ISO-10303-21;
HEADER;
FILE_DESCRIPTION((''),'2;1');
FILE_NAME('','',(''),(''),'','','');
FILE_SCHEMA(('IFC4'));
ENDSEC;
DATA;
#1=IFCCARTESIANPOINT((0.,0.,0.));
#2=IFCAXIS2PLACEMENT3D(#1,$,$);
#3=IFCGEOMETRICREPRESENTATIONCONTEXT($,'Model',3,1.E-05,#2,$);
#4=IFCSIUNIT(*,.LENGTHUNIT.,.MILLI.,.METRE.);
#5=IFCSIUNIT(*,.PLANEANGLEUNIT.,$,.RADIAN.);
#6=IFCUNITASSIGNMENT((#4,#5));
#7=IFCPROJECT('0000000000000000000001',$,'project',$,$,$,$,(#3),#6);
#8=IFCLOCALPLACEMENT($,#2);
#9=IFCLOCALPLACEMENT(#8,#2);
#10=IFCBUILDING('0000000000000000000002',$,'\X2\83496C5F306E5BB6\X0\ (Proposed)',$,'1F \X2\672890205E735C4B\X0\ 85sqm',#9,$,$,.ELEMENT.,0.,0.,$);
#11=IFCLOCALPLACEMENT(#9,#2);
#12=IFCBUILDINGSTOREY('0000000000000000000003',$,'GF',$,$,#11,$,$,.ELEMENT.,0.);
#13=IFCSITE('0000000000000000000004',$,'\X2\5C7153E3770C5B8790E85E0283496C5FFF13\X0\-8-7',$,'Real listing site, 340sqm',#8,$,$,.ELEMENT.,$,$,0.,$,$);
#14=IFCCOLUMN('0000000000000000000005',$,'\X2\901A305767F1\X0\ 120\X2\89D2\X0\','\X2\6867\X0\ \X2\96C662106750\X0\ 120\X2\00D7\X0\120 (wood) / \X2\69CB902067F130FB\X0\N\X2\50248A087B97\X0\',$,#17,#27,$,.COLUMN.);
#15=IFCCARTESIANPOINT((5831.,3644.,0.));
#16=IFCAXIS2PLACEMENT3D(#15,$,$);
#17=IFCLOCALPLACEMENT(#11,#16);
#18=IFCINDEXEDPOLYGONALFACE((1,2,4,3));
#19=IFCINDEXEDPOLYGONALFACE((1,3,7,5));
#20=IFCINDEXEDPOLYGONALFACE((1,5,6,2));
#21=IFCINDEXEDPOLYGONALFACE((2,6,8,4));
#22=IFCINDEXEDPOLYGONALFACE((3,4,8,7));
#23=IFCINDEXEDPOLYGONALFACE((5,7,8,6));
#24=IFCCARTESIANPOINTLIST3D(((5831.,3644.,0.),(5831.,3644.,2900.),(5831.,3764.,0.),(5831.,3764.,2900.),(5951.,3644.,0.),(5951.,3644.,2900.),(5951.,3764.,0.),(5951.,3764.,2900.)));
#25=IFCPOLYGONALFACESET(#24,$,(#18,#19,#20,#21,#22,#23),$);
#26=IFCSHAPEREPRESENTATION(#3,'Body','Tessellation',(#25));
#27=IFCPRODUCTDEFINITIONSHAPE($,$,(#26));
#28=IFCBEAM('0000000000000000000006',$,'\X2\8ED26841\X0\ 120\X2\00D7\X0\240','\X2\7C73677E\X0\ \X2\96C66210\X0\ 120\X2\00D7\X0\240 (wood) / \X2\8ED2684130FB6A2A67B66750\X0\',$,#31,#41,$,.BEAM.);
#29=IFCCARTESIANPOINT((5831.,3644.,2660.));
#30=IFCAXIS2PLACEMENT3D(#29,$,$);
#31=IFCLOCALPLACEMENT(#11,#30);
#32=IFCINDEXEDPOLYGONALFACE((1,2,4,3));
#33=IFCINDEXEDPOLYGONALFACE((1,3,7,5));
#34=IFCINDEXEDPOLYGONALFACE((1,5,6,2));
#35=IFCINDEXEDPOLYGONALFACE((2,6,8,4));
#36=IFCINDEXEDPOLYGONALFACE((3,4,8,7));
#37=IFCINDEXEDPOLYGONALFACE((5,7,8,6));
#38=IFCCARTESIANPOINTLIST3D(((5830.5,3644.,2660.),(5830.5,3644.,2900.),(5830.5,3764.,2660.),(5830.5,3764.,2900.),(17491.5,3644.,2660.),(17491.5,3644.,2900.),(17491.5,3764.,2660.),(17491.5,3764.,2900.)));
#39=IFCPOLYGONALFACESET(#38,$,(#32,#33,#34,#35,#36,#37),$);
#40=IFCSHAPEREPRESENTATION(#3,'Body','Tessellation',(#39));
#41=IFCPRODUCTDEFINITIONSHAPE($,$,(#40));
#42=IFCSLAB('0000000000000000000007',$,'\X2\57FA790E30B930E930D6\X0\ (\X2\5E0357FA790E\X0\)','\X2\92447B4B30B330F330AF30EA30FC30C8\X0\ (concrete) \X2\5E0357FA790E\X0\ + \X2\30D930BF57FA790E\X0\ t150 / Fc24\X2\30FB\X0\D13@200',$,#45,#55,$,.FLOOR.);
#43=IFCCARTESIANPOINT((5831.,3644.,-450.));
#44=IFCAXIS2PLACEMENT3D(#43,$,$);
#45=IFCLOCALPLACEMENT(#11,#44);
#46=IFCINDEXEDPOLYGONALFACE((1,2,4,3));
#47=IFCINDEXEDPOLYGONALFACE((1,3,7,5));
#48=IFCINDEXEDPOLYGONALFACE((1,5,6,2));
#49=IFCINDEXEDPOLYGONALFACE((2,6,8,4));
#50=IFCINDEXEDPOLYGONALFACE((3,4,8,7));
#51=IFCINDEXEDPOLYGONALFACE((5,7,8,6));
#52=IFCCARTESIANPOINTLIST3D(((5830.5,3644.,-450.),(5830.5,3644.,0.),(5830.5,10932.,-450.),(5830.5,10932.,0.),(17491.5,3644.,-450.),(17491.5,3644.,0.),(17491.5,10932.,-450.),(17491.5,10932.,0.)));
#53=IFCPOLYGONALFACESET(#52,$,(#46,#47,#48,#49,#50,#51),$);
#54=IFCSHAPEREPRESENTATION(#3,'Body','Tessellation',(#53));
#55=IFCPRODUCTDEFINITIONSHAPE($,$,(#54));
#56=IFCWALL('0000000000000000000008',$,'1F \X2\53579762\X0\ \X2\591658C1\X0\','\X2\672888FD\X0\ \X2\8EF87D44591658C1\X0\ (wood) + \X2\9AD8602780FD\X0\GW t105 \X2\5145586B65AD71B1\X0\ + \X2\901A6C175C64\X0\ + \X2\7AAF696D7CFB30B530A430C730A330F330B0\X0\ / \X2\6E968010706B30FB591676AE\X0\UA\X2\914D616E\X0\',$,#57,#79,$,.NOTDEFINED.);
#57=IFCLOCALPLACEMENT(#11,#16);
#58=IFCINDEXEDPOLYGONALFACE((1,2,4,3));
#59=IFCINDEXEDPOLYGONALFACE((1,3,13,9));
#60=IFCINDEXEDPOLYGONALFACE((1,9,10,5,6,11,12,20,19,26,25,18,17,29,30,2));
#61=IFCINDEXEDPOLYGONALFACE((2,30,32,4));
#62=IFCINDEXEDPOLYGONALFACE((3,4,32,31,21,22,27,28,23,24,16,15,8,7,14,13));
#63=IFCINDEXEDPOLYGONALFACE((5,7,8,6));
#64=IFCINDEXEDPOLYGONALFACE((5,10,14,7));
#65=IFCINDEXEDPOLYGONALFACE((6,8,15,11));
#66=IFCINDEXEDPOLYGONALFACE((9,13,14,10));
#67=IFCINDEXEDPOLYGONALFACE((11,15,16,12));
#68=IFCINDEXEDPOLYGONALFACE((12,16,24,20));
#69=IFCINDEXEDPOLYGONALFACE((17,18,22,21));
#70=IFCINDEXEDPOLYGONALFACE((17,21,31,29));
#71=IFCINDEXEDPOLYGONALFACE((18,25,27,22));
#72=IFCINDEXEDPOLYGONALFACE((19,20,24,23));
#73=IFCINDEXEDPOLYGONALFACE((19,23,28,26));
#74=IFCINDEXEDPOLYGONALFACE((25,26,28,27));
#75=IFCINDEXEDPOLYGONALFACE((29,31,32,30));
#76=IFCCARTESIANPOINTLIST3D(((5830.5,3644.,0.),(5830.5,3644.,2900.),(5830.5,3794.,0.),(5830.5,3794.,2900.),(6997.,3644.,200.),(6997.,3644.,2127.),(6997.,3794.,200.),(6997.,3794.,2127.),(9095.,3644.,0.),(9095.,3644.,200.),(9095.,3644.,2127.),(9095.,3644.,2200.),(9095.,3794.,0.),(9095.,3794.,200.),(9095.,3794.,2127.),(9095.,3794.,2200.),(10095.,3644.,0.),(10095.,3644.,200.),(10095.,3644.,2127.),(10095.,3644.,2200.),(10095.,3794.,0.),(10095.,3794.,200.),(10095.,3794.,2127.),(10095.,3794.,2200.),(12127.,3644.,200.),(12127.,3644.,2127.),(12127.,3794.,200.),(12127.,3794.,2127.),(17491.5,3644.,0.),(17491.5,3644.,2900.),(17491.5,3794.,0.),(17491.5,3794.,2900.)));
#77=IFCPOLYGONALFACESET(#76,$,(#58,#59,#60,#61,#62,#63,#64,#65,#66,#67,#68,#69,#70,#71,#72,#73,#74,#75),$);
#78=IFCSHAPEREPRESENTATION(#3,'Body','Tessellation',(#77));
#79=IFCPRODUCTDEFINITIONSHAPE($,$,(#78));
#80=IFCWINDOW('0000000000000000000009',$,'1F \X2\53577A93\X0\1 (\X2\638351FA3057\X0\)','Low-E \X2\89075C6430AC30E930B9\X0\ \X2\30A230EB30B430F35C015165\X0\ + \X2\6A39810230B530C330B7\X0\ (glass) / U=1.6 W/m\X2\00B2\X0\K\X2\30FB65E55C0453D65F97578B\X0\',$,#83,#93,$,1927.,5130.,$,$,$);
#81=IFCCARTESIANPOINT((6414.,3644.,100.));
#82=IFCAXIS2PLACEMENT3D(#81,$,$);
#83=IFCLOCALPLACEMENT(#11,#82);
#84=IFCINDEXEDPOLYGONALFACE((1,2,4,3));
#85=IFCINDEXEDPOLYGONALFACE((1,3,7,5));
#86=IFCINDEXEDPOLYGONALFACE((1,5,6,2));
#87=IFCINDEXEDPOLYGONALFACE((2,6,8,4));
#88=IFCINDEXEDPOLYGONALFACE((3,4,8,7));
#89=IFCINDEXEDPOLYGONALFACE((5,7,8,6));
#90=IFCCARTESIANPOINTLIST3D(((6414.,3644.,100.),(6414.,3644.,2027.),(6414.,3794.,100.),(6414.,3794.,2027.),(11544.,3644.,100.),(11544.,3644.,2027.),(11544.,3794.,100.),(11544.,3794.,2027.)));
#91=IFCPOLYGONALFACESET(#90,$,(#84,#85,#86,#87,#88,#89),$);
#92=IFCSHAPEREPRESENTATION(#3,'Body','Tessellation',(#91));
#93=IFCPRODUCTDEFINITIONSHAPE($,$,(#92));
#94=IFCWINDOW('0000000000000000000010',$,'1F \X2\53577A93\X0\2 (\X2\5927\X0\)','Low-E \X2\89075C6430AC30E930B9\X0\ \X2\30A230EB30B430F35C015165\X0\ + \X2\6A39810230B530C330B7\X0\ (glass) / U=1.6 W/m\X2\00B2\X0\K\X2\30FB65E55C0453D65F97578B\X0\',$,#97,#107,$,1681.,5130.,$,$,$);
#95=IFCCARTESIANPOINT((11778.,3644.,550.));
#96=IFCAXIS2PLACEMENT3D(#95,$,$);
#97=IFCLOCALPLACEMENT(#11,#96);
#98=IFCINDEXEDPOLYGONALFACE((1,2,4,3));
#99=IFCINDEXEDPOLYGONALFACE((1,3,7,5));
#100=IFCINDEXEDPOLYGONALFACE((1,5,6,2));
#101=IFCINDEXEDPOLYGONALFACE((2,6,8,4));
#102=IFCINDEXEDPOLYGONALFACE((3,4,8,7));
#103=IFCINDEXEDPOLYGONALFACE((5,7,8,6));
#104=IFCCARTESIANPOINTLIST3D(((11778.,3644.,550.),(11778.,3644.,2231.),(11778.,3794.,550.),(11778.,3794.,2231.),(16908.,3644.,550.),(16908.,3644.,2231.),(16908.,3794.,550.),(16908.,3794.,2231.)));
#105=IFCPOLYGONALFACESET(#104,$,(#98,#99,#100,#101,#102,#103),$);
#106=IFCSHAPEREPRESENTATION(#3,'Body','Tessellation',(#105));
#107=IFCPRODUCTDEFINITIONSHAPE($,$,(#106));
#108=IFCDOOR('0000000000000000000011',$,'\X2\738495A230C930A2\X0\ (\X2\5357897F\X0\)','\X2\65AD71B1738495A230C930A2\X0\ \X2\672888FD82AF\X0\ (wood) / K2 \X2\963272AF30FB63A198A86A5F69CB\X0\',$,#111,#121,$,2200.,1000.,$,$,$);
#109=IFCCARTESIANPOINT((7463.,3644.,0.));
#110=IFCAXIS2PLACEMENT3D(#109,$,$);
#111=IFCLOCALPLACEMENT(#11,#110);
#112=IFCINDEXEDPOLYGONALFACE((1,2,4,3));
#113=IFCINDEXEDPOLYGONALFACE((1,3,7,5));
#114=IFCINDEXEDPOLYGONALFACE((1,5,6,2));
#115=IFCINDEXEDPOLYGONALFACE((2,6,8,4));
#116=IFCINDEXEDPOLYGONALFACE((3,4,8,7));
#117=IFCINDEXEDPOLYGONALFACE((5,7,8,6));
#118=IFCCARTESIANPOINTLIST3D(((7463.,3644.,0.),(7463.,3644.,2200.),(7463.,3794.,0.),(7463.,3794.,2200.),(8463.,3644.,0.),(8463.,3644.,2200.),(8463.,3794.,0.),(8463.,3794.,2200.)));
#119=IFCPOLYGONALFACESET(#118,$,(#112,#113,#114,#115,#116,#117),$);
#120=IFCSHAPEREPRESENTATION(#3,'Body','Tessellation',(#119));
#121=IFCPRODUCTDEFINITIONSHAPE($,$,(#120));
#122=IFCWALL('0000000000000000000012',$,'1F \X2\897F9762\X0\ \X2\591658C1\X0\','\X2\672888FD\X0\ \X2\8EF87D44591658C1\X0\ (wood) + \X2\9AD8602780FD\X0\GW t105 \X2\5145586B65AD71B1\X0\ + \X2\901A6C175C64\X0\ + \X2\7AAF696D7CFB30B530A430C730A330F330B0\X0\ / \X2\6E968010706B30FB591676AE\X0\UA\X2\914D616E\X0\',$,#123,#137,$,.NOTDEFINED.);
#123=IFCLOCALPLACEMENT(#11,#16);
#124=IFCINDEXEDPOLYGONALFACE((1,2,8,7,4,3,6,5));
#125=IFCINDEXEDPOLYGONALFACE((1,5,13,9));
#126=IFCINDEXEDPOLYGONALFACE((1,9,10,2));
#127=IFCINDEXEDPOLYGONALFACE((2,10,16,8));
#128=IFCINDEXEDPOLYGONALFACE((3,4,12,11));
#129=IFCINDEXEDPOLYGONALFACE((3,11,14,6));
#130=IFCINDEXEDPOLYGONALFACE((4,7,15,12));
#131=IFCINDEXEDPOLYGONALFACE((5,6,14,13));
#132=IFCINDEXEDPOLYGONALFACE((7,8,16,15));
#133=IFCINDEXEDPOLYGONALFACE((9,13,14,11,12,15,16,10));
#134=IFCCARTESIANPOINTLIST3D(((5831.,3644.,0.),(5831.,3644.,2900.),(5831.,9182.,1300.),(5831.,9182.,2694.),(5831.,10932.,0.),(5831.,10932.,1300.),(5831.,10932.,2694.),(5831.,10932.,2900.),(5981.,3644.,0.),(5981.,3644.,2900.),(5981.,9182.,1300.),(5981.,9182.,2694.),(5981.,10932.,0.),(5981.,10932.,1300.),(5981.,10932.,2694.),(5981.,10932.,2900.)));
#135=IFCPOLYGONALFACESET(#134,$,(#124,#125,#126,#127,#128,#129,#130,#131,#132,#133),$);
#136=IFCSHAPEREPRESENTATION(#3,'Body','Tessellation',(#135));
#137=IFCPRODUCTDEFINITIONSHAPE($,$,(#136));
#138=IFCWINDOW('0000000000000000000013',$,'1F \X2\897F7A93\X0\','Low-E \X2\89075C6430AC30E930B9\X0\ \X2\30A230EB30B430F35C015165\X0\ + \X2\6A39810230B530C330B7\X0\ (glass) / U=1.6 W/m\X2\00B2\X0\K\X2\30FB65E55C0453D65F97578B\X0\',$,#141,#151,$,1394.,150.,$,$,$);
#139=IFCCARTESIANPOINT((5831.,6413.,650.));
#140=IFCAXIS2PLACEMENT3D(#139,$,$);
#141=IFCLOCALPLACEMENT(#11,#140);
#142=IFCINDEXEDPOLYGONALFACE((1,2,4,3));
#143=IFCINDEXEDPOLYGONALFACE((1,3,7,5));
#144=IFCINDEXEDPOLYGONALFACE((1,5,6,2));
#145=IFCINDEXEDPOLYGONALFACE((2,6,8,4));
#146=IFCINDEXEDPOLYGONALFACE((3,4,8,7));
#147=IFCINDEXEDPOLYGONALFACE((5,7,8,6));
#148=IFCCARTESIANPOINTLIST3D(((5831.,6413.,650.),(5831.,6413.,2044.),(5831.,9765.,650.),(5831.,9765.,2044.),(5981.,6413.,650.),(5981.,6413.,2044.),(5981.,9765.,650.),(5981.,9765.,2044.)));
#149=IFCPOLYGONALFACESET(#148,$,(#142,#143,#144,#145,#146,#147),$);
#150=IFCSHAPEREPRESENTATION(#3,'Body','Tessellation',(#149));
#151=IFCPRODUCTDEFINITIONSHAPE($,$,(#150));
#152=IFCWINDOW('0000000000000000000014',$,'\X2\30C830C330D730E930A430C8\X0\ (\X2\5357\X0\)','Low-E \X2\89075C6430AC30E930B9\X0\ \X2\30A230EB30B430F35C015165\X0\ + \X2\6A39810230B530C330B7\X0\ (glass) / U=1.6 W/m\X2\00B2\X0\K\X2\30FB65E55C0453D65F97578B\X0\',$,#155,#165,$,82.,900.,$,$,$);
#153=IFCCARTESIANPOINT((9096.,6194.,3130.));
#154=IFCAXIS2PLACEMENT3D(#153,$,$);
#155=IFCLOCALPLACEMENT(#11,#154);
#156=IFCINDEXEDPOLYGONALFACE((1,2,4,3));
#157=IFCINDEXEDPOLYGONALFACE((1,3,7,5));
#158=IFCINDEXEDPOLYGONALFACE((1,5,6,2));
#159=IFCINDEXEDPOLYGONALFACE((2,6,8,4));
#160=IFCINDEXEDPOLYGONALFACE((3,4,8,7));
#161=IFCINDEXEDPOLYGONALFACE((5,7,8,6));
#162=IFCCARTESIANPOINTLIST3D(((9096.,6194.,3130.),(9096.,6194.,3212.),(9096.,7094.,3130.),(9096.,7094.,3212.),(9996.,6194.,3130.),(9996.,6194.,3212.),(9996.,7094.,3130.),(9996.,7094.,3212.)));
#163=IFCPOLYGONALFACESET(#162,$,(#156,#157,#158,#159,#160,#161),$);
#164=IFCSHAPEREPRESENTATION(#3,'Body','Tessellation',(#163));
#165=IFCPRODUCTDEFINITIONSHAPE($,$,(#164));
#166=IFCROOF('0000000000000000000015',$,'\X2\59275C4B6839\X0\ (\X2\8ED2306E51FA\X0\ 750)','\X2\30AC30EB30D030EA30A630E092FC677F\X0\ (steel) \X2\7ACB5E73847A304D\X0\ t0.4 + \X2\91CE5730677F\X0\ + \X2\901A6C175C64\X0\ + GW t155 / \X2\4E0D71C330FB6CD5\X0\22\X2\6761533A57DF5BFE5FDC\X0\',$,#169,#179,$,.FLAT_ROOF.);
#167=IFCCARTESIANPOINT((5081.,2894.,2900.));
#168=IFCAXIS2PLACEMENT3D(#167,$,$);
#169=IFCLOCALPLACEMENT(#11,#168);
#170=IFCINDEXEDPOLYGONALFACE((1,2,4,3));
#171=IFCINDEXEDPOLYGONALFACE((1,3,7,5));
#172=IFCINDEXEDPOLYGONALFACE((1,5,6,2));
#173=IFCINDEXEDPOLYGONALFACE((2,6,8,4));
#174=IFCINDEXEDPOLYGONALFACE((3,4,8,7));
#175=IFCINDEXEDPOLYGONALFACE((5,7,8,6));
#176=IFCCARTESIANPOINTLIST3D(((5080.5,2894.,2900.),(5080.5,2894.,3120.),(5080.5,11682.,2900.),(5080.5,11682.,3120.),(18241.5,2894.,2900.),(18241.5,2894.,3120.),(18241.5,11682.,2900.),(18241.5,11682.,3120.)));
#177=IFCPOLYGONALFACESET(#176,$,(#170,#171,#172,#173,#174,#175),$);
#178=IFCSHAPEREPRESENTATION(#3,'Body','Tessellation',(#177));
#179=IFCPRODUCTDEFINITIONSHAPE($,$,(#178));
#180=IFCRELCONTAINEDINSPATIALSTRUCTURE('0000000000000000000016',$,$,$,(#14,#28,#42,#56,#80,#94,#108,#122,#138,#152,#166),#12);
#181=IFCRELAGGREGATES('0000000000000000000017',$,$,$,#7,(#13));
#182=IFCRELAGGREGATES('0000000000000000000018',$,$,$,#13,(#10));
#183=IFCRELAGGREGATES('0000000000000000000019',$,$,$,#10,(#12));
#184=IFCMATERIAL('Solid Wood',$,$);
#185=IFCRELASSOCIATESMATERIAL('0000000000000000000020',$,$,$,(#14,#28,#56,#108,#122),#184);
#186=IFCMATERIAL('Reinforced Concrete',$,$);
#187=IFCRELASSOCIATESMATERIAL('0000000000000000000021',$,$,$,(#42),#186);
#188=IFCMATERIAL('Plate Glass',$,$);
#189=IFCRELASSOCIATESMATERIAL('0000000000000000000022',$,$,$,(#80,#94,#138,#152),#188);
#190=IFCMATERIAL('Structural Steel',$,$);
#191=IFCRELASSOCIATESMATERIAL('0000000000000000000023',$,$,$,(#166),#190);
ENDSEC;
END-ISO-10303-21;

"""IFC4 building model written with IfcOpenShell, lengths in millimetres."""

from ifc_helpers import new_model, si_unit, frame, frame_2d, origin, place, context, project, spatial, rectangle, extrude, material, element, fill, save


model = new_model("IFC4")

# Units and contexts
model_context = context("Model", 3, precision=1e-05, world=origin())
ifc_project = project(units=[si_unit("LENGTHUNIT", "METRE", prefix="MILLI"), si_unit("PLANEANGLEUNIT", "RADIAN")], contexts=[model_context])

# Site, building, storey
site_placement = place(None, origin())
site = spatial("IfcSite", under=ifc_project, at=site_placement, Name="山口県宇部市草江３-8-7", ObjectType="Real listing site, 340sqm", CompositionType="ELEMENT", RefElevation=0.0)
building_placement = place(site_placement, origin())
building = spatial("IfcBuilding", under=site, at=building_placement, Name="草江の家 (Proposed)", ObjectType="1F 木造平屋 85sqm", CompositionType="ELEMENT", ElevationOfRefHeight=0.0, ElevationOfTerrain=0.0)
storey_placement = place(building_placement, origin())
storey = spatial("IfcBuildingStorey", under=building, at=storey_placement, Name="GF", CompositionType="ELEMENT", Elevation=0.0)

# Column
ifc_material_1 = material(Name="Solid Wood")
column_1_placement = place(storey_placement, frame((5831.0, 3644.0, 0.0)))
element("IfcColumn", 1, at=column_1_placement, inside=storey, material=ifc_material_1, Name="通し柱 120角", Description="桧 集成材 120×120 (wood) / 構造柱・N値計算", PredefinedType="COLUMN", context=model_context, shape_type="SweptSolid", body=[
    extrude(rectangle(XDim=120.0, YDim=120.0, at=frame_2d((60.0, 60.0))), frame((5831.0, 3644.0, 0.0)), (0.0, 0.0, 1.0), 2900.0),
])

# Beam
beam_1_placement = place(storey_placement, frame((5831.0, 3644.0, 2660.0)))
element("IfcBeam", 2, at=beam_1_placement, inside=storey, material=ifc_material_1, Name="軒桁 120×240", Description="米松 集成 120×240 (wood) / 軒桁・横架材", PredefinedType="BEAM", context=model_context, shape_type="SweptSolid", body=[
    extrude(rectangle(XDim=11661.0, YDim=120.0, at=frame_2d((5830.0, 60.0))), frame((5831.0, 3644.0, 2660.0)), (0.0, 0.0, 1.0), 240.0),
])

# Slab
ifc_material_2 = material(Name="Reinforced Concrete")
slab_1_placement = place(storey_placement, frame((5831.0, 3644.0, -450.0)))
element("IfcSlab", 3, at=slab_1_placement, inside=storey, material=ifc_material_2, Name="基礎スラブ (布基礎)", Description="鉄筋コンクリート (concrete) 布基礎 + ベタ基礎 t150 / Fc24・D13@200", PredefinedType="FLOOR", context=model_context, shape_type="SweptSolid", body=[
    extrude(rectangle(XDim=11661.0, YDim=7288.0, at=frame_2d((5830.0, 3644.0))), frame((5831.0, 3644.0, -450.0)), (0.0, 0.0, 1.0), 450.0),
])

# Wall, openings, windows, door
wall_1_placement = place(storey_placement, frame((5831.0, 3644.0, 0.0)))
wall_1 = element("IfcWall", 4, at=wall_1_placement, inside=storey, material=ifc_material_1, Name="1F 南面 外壁", Description="木製 軸組外壁 (wood) + 高性能GW t105 充填断熱 + 通気層 + 窯業系サイディング / 準耐火・外皮UA配慮", PredefinedType="NOTDEFINED", context=model_context, shape_type="SweptSolid", body=[
    extrude(rectangle(XDim=11661.0, YDim=150.0, at=frame_2d((5830.0, 75.0))), frame((5831.0, 3644.0, 0.0)), (0.0, 0.0, 1.0), 2900.0),
])
opening_1_placement = place(storey_placement, frame((6414.0, 3644.0, 100.0)))
opening_1 = element("IfcOpeningElement", 5, at=opening_1_placement, cuts=wall_1, PredefinedType="NOTDEFINED", context=model_context, shape_type="SweptSolid", body=[
    extrude(rectangle(XDim=5130.0, YDim=150.0, at=frame_2d((2565.0, 75.0))), frame((6414.0, 3644.0, 100.0)), (0.0, 0.0, 1.0), 1927.0),
])
opening_2_placement = place(storey_placement, frame((11778.0, 3644.0, 550.0)))
opening_2 = element("IfcOpeningElement", 6, at=opening_2_placement, cuts=wall_1, PredefinedType="NOTDEFINED", context=model_context, shape_type="SweptSolid", body=[
    extrude(rectangle(XDim=5130.0, YDim=150.0, at=frame_2d((2565.0, 75.0))), frame((11778.0, 3644.0, 550.0)), (0.0, 0.0, 1.0), 1681.0),
])
opening_3_placement = place(storey_placement, frame((7463.0, 3644.0, 0.0)))
opening_3 = element("IfcOpeningElement", 7, at=opening_3_placement, cuts=wall_1, PredefinedType="NOTDEFINED", context=model_context, shape_type="SweptSolid", body=[
    extrude(rectangle(XDim=1000.0, YDim=150.0, at=frame_2d((500.0, 75.0))), frame((7463.0, 3644.0, 0.0)), (0.0, 0.0, 1.0), 2200.0),
])
ifc_material_3 = material(Name="Plate Glass")
window_1_placement = place(storey_placement, frame((6414.0, 3644.0, 100.0)))
window_1 = element("IfcWindow", 8, at=window_1_placement, inside=storey, material=ifc_material_3, Name="1F 南窓1 (掃出し)", Description="Low-E 複層ガラス アルゴン封入 + 樹脂サッシ (glass) / U=1.6 W/m²K・日射取得型", OverallHeight=1927.0, OverallWidth=5130.0, context=model_context, shape_type="SweptSolid", body=[
    extrude(rectangle(XDim=5130.0, YDim=150.0, at=frame_2d((2565.0, 75.0))), frame((6414.0, 3644.0, 100.0)), (0.0, 0.0, 1.0), 1927.0),
])
fill(opening_1, window_1)
window_2_placement = place(storey_placement, frame((11778.0, 3644.0, 550.0)))
window_2 = element("IfcWindow", 9, at=window_2_placement, inside=storey, material=ifc_material_3, Name="1F 南窓2 (大)", Description="Low-E 複層ガラス アルゴン封入 + 樹脂サッシ (glass) / U=1.6 W/m²K・日射取得型", OverallHeight=1681.0, OverallWidth=5130.0, context=model_context, shape_type="SweptSolid", body=[
    extrude(rectangle(XDim=5130.0, YDim=150.0, at=frame_2d((2565.0, 75.0))), frame((11778.0, 3644.0, 550.0)), (0.0, 0.0, 1.0), 1681.0),
])
fill(opening_2, window_2)
door_placement = place(storey_placement, frame((7463.0, 3644.0, 0.0)))
door = element("IfcDoor", 10, at=door_placement, inside=storey, material=ifc_material_1, Name="玄関ドア (南西)", Description="断熱玄関ドア 木製芯 (wood) / K2 防犯・採風機構", OverallHeight=2200.0, OverallWidth=1000.0, context=model_context, shape_type="SweptSolid", body=[
    extrude(rectangle(XDim=1000.0, YDim=150.0, at=frame_2d((500.0, 75.0))), frame((7463.0, 3644.0, 0.0)), (0.0, 0.0, 1.0), 2200.0),
])
fill(opening_3, door)

# Wall, opening, window
wall_2_placement = place(storey_placement, frame((5831.0, 3644.0, 0.0)))
wall_2 = element("IfcWall", 11, at=wall_2_placement, inside=storey, material=ifc_material_1, Name="1F 西面 外壁", Description="木製 軸組外壁 (wood) + 高性能GW t105 充填断熱 + 通気層 + 窯業系サイディング / 準耐火・外皮UA配慮", PredefinedType="NOTDEFINED", context=model_context, shape_type="SweptSolid", body=[
    extrude(rectangle(XDim=150.0, YDim=7288.0, at=frame_2d((75.0, 3644.0))), frame((5831.0, 3644.0, 0.0)), (0.0, 0.0, 1.0), 2900.0),
])
opening_4_placement = place(storey_placement, frame((5831.0, 6413.0, 650.0)))
opening_4 = element("IfcOpeningElement", 12, at=opening_4_placement, cuts=wall_2, PredefinedType="NOTDEFINED", context=model_context, shape_type="SweptSolid", body=[
    extrude(rectangle(XDim=150.0, YDim=3352.0, at=frame_2d((75.0, 1676.0))), frame((5831.0, 6413.0, 650.0)), (0.0, 0.0, 1.0), 1394.0),
])
window_3_placement = place(storey_placement, frame((5831.0, 6413.0, 650.0)))
window_3 = element("IfcWindow", 13, at=window_3_placement, inside=storey, material=ifc_material_3, Name="1F 西窓", Description="Low-E 複層ガラス アルゴン封入 + 樹脂サッシ (glass) / U=1.6 W/m²K・日射取得型", OverallHeight=1394.0, OverallWidth=150.0, context=model_context, shape_type="SweptSolid", body=[
    extrude(rectangle(XDim=150.0, YDim=3352.0, at=frame_2d((75.0, 1676.0))), frame((5831.0, 6413.0, 650.0)), (0.0, 0.0, 1.0), 1394.0),
])
fill(opening_4, window_3)

# Window
window_4_placement = place(storey_placement, frame((9096.0, 6194.0, 3130.0)))
element("IfcWindow", 14, at=window_4_placement, inside=storey, material=ifc_material_3, Name="トップライト (南)", Description="Low-E 複層ガラス アルゴン封入 + 樹脂サッシ (glass) / U=1.6 W/m²K・日射取得型", OverallHeight=82.0, OverallWidth=900.0, context=model_context, shape_type="SweptSolid", body=[
    extrude(rectangle(XDim=900.0, YDim=900.0, at=frame_2d((450.0, 450.0))), frame((9096.0, 6194.0, 3130.0)), (0.0, 0.0, 1.0), 82.0),
])

# Roof
ifc_material_4 = material(Name="Structural Steel")
roof_placement = place(storey_placement, frame((5081.0, 2894.0, 2900.0)))
element("IfcRoof", 15, at=roof_placement, inside=storey, material=ifc_material_4, Name="大屋根 (軒の出 750)", Description="ガルバリウム鋼板 (steel) 立平葺き t0.4 + 野地板 + 通気層 + GW t155 / 不燃・法22条区域対応", PredefinedType="FLAT_ROOF", context=model_context, shape_type="SweptSolid", body=[
    extrude(rectangle(XDim=13161.0, YDim=8788.0, at=frame_2d((6580.0, 4394.0))), frame((5081.0, 2894.0, 2900.0)), (0.0, 0.0, 1.0), 220.0),
])

save(model, "model.ifc")
